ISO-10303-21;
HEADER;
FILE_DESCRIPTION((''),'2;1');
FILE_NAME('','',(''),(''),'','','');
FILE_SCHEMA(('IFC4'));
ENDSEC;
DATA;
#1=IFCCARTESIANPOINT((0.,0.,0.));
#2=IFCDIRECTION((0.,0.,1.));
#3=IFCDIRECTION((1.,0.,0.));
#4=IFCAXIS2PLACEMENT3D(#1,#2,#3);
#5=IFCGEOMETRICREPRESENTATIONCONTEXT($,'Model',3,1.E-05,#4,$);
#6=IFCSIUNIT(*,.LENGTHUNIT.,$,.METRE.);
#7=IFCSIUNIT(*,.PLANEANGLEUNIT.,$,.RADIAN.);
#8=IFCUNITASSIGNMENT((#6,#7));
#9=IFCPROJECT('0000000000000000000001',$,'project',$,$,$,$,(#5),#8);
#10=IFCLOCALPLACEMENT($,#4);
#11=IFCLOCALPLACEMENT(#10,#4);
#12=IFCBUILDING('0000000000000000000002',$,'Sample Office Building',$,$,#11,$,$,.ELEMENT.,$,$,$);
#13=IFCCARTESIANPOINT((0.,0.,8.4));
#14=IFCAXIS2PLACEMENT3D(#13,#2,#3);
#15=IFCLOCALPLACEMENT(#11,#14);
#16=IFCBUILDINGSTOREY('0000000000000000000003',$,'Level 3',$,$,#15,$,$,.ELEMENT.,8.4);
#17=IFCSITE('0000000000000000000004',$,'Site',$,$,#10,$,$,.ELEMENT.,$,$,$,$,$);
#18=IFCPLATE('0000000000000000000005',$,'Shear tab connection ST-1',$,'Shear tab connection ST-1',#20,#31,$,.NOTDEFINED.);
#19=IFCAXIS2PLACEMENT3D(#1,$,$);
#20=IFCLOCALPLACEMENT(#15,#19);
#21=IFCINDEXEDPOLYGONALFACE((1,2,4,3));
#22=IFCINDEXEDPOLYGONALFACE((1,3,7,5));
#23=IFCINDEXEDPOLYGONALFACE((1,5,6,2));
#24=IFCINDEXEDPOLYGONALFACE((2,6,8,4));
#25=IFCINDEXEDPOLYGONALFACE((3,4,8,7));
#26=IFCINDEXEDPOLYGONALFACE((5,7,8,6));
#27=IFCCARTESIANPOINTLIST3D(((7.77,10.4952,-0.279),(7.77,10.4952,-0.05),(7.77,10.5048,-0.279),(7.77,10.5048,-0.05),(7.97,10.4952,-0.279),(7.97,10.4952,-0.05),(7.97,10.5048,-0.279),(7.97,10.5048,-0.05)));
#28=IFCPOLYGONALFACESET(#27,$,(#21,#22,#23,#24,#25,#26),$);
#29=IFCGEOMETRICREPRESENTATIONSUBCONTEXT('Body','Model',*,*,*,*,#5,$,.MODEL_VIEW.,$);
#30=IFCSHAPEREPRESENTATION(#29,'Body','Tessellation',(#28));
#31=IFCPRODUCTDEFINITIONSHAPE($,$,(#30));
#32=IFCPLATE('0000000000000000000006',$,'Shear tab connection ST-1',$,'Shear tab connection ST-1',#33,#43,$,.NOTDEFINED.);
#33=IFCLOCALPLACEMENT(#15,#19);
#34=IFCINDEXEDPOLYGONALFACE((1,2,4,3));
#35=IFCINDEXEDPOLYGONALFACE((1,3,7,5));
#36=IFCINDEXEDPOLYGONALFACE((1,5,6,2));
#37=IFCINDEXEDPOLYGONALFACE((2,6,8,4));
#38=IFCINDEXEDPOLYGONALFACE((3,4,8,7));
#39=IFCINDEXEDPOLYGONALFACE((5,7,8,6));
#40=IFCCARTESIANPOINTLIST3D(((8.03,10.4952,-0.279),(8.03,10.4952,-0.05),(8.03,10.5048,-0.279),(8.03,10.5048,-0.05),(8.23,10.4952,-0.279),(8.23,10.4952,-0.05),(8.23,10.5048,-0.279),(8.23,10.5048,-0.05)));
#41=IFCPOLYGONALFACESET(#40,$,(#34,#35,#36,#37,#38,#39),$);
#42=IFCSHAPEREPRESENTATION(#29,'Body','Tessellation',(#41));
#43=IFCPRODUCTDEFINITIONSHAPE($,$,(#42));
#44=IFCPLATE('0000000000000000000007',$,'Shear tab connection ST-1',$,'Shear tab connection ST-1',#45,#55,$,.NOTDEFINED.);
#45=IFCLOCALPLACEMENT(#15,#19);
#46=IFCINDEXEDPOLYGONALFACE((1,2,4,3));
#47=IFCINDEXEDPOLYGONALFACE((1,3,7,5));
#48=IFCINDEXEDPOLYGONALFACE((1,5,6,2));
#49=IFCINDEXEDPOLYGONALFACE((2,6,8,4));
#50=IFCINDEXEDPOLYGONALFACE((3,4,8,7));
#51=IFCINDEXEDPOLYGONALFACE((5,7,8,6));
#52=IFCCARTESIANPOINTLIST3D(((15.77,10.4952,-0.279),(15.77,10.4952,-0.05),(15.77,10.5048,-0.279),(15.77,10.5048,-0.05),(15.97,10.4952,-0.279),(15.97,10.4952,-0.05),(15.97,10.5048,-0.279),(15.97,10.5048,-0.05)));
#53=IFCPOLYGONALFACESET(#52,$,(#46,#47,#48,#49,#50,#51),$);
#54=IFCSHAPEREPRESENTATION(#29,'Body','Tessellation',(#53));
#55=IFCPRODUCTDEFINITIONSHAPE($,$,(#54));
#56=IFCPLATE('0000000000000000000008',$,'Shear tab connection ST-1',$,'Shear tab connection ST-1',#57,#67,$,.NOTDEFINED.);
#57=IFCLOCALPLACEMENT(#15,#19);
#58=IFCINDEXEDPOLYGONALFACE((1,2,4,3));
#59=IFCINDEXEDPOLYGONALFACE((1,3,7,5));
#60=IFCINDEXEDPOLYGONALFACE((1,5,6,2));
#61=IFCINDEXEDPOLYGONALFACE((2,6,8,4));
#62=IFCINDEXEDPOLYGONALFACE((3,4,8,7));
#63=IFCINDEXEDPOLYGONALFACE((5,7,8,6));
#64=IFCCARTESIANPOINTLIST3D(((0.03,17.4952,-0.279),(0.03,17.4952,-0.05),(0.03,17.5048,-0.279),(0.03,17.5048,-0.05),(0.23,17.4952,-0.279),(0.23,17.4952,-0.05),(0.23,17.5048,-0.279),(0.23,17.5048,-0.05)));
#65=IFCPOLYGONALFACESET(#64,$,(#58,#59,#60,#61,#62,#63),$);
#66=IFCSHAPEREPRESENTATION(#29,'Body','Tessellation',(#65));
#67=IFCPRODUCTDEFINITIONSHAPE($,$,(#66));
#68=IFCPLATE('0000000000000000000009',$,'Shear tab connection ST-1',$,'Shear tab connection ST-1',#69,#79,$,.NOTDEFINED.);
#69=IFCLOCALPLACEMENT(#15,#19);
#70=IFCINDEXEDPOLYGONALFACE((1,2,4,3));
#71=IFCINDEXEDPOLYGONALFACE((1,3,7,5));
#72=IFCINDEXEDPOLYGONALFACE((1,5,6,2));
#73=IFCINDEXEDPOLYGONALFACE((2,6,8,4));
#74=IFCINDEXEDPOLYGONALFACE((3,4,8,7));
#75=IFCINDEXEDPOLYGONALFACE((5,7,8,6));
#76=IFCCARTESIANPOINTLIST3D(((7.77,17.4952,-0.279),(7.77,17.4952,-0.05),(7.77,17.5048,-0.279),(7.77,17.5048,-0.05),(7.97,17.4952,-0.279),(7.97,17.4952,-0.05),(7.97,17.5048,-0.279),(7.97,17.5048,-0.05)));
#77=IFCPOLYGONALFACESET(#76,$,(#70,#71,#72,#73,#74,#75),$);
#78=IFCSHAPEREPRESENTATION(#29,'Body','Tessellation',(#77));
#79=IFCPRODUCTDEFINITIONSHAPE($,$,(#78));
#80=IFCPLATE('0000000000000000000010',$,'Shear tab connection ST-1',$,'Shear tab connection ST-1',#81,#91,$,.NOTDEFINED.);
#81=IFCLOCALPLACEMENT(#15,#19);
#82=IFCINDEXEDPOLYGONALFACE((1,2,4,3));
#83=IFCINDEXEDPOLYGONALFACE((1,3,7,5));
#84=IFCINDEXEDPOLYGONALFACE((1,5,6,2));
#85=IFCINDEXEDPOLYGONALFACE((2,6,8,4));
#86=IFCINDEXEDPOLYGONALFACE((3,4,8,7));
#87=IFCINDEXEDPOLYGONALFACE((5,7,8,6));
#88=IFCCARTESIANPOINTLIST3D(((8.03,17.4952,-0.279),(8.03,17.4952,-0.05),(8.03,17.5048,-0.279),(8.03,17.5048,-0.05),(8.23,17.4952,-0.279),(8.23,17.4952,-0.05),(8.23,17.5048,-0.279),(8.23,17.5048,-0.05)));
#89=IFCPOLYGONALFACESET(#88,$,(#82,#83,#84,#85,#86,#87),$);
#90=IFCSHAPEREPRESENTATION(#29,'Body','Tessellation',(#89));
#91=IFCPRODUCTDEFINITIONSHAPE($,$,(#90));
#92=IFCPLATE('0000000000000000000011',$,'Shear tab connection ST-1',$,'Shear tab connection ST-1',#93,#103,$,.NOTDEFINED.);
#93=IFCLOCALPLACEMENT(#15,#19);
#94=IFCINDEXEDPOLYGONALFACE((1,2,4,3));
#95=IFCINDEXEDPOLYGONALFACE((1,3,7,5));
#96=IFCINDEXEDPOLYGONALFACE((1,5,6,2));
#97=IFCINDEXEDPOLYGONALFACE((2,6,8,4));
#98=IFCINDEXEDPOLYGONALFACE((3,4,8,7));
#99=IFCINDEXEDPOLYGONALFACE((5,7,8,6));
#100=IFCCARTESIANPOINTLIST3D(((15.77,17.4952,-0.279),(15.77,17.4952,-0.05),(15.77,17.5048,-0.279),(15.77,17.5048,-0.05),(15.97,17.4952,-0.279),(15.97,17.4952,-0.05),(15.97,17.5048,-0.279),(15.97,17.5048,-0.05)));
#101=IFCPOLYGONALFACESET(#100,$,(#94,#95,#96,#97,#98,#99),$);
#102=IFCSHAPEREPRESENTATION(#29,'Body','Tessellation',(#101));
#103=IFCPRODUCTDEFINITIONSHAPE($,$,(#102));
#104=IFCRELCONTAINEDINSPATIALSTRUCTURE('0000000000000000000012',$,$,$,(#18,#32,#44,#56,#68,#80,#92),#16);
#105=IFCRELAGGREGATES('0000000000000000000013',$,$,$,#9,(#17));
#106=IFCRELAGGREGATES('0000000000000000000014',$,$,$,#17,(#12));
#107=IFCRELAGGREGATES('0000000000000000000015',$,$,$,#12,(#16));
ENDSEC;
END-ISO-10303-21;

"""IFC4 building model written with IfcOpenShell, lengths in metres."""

from ifc_helpers import new_model, si_unit, frame, origin_with_axes, place, context, subcontext, project, spatial, rectangle, extrude, element, save


model = new_model("IFC4")

# Units and contexts
model_context = context("Model", 3, precision=1e-05, world=origin_with_axes())
body_context = subcontext(model_context, "Body", "Model", "MODEL_VIEW")
ifc_project = project(units=[si_unit("LENGTHUNIT", "METRE"), si_unit("PLANEANGLEUNIT", "RADIAN")], contexts=[model_context])

# Site, building, storey
site_placement = place(None, origin_with_axes())
site = spatial("IfcSite", under=ifc_project, at=site_placement, Name="Site", CompositionType="ELEMENT")
building_placement = place(site_placement, origin_with_axes())
building = spatial("IfcBuilding", under=site, at=building_placement, Name="Sample Office Building", CompositionType="ELEMENT")
storey_placement = place(building_placement, frame((0.0, 0.0, 8.4), z_axis=(0.0, 0.0, 1.0), x_axis=(1.0, 0.0, 0.0)))
storey = spatial("IfcBuildingStorey", under=building, at=storey_placement, Name="Level 3", CompositionType="ELEMENT", Elevation=8.4)

# Plates
plate_1_placement = place(None, frame((7.87, 10.5, 8.121), z_axis=(0.0, 0.0, 1.0), x_axis=(1.0, 0.0, 0.0)))
element("IfcPlate", 1, at=plate_1_placement, inside=storey, Name="Shear tab connection ST-1", ObjectType="Shear tab connection ST-1", PredefinedType="NOTDEFINED", context=body_context, shape_type="SweptSolid", body=[
    extrude(rectangle(XDim=0.2, YDim=0.0095), None, (0.0, 0.0, 1.0), 0.229),
])
for number, where, z_axis, x_axis, name in (
    (2, (8.13, 10.5, 8.121), (0.0, 0.0, 1.0), (1.0, 0.0, 0.0), "Shear tab connection ST-1"),
    (3, (15.87, 10.5, 8.121), (0.0, 0.0, 1.0), (1.0, 0.0, 0.0), "Shear tab connection ST-1"),
):
    element("IfcPlate", number, at=place(None, frame(where, z_axis=z_axis, x_axis=x_axis)), inside=storey, Name=name, ObjectType="Shear tab connection ST-1", PredefinedType="NOTDEFINED", context=body_context, shape_type="SweptSolid", body=[
        extrude(rectangle(XDim=0.2, YDim=0.0095), None, (0.0, 0.0, 1.0), 0.229),
    ])
plate_2_placement = place(None, frame((0.13, 17.5, 8.121), z_axis=(0.0, 0.0, 1.0), x_axis=(1.0, 0.0, 0.0)))
element("IfcPlate", 4, at=plate_2_placement, inside=storey, Name="Shear tab connection ST-1", ObjectType="Shear tab connection ST-1", PredefinedType="NOTDEFINED", context=body_context, shape_type="SweptSolid", body=[
    extrude(rectangle(XDim=0.2, YDim=0.0095), None, (0.0, 0.0, 1.0), 0.229),
])
plate_3_placement = place(None, frame((7.87, 17.5, 8.121), z_axis=(0.0, 0.0, 1.0), x_axis=(1.0, 0.0, 0.0)))
element("IfcPlate", 5, at=plate_3_placement, inside=storey, Name="Shear tab connection ST-1", ObjectType="Shear tab connection ST-1", PredefinedType="NOTDEFINED", context=body_context, shape_type="SweptSolid", body=[
    extrude(rectangle(XDim=0.2, YDim=0.0095), None, (0.0, 0.0, 1.0), 0.229),
])
for number, where, z_axis, x_axis, name in (
    (6, (8.13, 17.5, 8.121), (0.0, 0.0, 1.0), (1.0, 0.0, 0.0), "Shear tab connection ST-1"),
    (7, (15.87, 17.5, 8.121), (0.0, 0.0, 1.0), (1.0, 0.0, 0.0), "Shear tab connection ST-1"),
):
    element("IfcPlate", number, at=place(None, frame(where, z_axis=z_axis, x_axis=x_axis)), inside=storey, Name=name, ObjectType="Shear tab connection ST-1", PredefinedType="NOTDEFINED", context=body_context, shape_type="SweptSolid", body=[
        extrude(rectangle(XDim=0.2, YDim=0.0095), None, (0.0, 0.0, 1.0), 0.229),
    ])

save(model, "model.ifc")
